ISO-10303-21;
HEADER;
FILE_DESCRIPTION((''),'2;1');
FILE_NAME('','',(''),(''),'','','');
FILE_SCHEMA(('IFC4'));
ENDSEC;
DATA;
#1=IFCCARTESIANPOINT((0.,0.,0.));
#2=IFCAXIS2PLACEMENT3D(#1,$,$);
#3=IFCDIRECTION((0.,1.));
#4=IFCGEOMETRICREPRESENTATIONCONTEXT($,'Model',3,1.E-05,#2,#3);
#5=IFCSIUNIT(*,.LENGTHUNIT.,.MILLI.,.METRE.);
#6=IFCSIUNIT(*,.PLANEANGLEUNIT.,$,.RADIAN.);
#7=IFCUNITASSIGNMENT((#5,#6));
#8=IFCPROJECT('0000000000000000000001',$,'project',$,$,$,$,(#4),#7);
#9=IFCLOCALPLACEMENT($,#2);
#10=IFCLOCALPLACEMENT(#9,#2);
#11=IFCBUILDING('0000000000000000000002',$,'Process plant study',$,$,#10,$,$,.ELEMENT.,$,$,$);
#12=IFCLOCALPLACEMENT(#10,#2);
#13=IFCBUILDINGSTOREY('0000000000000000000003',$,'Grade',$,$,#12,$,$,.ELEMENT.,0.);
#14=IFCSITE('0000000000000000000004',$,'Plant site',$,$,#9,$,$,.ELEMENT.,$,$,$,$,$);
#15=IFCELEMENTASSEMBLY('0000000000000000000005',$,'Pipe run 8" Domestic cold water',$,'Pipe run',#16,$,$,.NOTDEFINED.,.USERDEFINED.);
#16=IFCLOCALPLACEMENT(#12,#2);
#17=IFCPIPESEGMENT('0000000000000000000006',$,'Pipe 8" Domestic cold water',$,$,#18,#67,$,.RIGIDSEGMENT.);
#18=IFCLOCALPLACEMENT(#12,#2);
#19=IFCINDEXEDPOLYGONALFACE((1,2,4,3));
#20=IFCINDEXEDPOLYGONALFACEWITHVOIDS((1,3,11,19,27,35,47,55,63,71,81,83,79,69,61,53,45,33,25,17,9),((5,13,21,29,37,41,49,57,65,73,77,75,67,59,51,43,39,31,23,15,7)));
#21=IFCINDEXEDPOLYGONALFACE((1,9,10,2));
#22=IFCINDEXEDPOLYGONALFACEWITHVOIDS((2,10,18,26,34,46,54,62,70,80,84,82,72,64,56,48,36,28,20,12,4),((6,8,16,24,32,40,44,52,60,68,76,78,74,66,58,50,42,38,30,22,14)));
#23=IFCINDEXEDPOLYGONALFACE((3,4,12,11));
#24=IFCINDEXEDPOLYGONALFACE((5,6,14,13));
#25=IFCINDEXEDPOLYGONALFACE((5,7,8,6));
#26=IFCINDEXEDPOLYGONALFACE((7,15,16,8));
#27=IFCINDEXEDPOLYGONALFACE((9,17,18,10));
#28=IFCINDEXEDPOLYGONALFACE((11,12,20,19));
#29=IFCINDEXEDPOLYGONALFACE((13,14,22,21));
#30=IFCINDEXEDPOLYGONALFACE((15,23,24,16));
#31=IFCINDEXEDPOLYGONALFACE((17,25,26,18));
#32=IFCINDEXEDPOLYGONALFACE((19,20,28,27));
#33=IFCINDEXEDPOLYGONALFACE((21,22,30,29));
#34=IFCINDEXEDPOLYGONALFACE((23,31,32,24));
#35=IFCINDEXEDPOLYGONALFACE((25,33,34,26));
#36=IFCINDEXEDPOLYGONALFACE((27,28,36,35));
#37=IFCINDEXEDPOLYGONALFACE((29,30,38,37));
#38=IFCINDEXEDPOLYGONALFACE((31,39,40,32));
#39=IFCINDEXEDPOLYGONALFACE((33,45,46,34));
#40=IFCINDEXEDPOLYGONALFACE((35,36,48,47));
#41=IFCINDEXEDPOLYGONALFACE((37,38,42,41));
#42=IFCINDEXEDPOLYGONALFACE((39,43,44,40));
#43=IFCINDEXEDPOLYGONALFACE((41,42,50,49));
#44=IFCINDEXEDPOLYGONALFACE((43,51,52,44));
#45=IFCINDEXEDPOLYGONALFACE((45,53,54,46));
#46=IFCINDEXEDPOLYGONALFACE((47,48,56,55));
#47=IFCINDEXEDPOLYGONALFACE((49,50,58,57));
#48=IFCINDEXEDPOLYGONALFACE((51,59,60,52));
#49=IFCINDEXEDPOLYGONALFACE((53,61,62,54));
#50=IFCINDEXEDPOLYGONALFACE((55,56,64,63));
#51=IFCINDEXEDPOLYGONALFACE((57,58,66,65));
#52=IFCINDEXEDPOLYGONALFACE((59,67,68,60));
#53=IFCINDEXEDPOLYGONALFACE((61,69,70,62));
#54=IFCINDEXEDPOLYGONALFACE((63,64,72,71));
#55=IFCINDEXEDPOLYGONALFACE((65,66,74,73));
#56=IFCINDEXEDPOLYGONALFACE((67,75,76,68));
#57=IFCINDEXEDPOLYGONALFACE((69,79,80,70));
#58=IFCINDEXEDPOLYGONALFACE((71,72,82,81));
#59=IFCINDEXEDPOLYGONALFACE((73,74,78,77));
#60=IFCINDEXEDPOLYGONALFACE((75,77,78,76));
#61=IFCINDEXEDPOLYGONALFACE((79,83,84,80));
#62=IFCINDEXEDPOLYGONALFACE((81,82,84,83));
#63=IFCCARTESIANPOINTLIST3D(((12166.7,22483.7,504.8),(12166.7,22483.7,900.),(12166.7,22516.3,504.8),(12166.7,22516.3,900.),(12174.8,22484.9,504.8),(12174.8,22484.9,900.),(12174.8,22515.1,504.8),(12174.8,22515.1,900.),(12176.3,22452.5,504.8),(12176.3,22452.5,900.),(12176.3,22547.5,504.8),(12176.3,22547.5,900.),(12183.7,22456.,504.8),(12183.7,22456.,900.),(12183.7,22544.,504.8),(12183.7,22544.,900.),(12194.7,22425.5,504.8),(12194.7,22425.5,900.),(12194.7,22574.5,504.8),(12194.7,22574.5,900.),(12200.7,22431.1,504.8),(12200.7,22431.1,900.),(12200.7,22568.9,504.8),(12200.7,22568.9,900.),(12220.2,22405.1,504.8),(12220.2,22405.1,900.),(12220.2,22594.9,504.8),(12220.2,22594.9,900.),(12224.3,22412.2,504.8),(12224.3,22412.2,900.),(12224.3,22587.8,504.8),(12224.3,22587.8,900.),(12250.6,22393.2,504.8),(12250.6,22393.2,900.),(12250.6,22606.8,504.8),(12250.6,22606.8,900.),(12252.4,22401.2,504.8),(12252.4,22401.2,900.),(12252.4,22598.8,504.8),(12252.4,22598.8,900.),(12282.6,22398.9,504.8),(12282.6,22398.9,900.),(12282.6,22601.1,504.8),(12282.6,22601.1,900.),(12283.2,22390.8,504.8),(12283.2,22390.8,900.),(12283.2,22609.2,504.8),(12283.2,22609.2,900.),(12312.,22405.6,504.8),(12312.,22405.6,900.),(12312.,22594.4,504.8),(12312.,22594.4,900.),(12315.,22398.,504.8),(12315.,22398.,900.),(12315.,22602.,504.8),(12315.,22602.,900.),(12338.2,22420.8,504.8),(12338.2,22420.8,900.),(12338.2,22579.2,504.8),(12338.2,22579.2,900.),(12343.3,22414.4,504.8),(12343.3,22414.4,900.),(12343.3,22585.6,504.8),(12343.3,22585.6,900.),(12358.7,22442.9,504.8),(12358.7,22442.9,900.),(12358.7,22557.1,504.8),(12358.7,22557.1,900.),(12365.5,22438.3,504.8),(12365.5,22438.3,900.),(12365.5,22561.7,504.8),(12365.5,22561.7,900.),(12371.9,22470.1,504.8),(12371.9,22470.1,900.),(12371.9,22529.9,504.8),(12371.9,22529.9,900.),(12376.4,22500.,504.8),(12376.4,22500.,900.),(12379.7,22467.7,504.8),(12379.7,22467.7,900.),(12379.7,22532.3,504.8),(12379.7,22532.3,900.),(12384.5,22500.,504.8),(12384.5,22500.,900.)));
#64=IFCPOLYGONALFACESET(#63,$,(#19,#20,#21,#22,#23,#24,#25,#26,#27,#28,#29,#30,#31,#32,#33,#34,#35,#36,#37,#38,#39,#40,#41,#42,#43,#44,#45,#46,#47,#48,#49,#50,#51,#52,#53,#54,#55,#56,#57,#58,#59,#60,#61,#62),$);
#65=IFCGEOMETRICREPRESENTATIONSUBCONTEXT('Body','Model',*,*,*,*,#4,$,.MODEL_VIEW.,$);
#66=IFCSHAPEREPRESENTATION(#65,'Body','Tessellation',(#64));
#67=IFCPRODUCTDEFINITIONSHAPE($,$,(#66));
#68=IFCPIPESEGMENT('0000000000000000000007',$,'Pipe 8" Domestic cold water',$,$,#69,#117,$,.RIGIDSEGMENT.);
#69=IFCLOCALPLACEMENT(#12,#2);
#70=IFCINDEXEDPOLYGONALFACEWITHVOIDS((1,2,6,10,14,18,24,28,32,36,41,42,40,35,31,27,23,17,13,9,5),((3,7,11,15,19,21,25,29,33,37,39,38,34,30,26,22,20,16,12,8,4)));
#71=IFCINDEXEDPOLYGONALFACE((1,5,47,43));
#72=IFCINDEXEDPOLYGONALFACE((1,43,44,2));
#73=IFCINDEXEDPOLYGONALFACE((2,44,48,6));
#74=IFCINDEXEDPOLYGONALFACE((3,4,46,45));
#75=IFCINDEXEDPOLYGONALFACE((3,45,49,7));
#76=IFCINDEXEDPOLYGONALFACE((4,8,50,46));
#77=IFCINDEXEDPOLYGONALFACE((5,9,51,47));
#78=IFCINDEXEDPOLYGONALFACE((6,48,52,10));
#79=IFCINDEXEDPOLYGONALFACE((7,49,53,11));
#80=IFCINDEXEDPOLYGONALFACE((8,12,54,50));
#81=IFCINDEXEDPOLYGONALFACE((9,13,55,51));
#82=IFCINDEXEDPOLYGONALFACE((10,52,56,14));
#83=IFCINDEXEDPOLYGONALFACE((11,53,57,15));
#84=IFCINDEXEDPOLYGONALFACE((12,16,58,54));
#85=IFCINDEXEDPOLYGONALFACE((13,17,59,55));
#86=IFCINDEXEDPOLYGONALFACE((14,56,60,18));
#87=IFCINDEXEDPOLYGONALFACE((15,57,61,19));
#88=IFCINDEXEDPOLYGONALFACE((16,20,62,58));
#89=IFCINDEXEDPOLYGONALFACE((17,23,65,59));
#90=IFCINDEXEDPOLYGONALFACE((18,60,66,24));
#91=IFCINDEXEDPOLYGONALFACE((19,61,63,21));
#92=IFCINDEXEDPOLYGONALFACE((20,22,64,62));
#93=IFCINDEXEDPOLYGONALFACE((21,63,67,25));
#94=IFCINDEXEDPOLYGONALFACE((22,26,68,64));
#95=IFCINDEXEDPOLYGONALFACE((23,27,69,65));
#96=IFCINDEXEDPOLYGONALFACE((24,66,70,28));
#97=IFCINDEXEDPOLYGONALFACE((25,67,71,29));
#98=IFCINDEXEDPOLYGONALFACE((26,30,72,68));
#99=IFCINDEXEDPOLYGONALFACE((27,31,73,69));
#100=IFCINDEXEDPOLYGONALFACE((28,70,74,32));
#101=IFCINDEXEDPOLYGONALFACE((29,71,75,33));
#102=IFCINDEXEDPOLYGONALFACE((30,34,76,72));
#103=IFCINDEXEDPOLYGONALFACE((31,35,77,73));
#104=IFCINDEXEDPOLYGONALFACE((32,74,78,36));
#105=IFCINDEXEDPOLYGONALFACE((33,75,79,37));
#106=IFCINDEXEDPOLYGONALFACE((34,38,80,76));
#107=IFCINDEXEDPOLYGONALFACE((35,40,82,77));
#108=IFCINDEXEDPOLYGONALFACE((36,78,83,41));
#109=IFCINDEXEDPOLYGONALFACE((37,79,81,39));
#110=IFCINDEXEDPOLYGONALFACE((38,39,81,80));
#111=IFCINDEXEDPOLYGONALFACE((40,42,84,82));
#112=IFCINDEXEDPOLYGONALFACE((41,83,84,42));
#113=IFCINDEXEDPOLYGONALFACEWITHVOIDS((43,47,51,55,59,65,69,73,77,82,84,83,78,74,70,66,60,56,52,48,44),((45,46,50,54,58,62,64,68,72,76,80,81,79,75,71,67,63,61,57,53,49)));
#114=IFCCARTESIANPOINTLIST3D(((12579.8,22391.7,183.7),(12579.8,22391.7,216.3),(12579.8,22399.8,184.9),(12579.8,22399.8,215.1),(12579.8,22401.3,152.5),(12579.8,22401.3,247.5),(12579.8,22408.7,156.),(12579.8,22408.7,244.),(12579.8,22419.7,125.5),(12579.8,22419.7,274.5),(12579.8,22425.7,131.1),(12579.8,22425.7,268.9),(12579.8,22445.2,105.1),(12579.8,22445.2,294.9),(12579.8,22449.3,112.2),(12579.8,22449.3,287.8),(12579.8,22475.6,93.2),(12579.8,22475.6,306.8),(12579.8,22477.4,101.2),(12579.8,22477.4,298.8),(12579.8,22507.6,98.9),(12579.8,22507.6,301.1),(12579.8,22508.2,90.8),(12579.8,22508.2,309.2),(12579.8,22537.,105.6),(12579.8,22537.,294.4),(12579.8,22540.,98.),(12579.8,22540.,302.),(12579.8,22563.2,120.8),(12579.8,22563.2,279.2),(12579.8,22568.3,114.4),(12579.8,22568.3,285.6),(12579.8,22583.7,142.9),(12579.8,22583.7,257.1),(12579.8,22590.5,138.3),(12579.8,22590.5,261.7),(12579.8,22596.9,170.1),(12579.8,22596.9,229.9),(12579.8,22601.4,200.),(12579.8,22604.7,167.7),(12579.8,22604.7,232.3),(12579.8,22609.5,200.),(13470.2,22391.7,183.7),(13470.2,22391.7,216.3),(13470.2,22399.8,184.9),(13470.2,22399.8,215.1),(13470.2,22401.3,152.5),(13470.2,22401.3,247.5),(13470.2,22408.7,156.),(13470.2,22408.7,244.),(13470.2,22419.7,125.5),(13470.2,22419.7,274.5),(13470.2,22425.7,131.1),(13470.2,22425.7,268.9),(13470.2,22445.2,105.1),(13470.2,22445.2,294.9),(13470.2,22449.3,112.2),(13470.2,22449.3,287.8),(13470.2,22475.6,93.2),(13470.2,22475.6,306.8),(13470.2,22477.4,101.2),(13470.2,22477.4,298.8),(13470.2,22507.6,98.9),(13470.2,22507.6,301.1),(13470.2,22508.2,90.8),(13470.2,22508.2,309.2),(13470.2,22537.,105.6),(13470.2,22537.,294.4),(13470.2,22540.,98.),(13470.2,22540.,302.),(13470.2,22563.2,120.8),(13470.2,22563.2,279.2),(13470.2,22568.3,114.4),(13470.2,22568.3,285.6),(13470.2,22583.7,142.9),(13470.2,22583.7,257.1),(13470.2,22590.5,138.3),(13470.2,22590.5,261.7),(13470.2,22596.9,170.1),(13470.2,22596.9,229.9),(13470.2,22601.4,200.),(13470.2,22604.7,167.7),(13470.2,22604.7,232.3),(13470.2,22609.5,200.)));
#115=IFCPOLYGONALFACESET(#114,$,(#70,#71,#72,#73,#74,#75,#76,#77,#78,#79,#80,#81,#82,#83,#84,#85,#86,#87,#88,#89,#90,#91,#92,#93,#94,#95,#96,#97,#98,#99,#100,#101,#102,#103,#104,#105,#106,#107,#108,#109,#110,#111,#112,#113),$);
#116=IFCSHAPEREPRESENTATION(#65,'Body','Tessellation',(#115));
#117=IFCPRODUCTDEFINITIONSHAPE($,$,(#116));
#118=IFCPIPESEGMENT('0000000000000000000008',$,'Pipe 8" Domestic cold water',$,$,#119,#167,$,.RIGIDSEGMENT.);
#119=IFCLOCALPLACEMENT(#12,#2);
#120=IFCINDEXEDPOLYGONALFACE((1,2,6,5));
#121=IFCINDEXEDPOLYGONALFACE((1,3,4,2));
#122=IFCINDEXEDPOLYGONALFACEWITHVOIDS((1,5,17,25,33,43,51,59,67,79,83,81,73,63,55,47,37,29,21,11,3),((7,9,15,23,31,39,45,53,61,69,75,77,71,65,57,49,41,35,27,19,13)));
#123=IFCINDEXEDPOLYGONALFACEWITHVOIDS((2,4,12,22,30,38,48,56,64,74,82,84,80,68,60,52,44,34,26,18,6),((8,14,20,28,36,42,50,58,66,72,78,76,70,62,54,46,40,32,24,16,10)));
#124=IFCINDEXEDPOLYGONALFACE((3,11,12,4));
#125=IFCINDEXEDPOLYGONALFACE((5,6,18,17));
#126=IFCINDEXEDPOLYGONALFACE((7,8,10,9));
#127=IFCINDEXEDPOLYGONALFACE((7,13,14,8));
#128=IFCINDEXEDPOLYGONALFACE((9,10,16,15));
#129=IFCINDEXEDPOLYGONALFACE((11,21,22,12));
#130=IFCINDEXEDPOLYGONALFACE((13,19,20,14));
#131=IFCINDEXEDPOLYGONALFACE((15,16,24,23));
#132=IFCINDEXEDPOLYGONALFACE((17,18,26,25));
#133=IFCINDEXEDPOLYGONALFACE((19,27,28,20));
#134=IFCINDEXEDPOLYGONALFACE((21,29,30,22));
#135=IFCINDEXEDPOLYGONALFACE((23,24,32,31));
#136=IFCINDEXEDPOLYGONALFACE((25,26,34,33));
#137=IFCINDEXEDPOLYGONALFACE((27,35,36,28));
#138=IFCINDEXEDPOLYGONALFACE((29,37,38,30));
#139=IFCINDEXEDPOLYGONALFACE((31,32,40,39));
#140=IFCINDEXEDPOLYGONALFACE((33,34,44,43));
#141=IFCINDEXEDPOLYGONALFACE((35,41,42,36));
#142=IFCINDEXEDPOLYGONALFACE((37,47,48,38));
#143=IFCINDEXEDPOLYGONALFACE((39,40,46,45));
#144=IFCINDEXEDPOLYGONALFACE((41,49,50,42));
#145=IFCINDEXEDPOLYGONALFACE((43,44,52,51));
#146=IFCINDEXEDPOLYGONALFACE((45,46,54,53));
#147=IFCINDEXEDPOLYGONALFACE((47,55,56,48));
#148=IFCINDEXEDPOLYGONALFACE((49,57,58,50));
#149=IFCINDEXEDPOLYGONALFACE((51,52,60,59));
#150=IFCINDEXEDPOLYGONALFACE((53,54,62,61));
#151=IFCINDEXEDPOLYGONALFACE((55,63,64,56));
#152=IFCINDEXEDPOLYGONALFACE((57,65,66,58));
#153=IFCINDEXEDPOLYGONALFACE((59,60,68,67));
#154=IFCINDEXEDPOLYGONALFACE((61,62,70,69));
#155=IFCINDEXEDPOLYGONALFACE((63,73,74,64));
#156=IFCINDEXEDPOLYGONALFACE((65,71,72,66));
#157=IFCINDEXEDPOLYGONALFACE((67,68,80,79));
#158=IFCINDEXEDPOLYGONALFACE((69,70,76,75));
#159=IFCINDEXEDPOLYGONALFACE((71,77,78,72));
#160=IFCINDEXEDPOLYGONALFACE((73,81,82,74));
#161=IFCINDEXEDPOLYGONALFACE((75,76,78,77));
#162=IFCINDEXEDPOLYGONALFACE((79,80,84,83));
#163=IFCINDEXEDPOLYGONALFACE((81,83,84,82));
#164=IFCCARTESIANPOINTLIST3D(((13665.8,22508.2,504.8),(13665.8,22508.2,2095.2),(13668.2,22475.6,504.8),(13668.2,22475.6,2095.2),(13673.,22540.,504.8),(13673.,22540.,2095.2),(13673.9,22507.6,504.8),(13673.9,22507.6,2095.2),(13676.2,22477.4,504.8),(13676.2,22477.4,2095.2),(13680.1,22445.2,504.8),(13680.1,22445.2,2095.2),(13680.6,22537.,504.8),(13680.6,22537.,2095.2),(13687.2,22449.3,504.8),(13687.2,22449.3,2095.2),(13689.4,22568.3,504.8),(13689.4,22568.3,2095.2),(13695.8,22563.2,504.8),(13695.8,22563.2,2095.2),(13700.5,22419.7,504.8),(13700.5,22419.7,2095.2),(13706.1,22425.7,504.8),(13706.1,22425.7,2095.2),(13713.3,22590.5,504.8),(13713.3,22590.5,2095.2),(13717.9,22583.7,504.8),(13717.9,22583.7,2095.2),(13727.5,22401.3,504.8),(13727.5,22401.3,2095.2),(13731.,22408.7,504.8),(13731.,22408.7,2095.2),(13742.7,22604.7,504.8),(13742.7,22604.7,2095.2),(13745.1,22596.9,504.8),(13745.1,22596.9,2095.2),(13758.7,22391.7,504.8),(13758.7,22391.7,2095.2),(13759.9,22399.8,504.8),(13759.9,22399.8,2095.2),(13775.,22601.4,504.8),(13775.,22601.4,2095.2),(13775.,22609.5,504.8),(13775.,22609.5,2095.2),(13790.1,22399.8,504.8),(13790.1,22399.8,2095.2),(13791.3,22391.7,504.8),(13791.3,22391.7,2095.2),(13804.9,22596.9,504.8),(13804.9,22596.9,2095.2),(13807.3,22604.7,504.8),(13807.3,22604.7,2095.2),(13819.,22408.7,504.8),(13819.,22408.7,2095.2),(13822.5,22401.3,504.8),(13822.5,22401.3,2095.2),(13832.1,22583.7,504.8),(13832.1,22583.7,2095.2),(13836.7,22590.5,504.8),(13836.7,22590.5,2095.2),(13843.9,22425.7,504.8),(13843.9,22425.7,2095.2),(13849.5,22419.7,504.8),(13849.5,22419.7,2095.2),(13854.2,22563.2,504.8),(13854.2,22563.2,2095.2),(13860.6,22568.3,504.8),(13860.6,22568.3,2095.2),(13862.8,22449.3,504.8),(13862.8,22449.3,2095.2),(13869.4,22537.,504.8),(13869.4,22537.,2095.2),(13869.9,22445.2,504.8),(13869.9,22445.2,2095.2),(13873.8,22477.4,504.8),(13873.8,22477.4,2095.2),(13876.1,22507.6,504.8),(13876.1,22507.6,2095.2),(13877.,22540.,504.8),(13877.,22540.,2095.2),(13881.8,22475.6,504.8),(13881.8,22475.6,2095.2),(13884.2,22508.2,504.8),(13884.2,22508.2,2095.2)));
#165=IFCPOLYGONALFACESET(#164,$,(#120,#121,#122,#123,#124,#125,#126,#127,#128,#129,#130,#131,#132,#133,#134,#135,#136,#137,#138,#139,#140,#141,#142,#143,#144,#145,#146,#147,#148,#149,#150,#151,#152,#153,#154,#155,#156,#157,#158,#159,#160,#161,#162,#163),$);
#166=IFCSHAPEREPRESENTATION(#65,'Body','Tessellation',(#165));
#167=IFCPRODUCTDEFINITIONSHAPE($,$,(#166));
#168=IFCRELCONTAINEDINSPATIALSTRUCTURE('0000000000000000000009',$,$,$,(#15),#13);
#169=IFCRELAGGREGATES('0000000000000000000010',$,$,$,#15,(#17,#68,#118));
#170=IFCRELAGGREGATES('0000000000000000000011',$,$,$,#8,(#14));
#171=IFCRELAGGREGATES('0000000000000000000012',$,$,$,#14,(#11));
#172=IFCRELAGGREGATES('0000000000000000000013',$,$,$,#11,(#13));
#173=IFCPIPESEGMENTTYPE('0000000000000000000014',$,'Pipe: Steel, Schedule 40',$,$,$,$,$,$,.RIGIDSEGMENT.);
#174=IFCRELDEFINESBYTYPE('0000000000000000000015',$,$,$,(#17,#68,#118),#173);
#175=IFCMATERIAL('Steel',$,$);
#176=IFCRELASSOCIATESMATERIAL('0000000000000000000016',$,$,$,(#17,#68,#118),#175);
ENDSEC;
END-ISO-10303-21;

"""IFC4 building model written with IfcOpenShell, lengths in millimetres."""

from ifc_helpers import new_model, si_unit, direction, frame, origin, origin_with_axes, origin_2d, place, context, subcontext, project, spatial, hollow_circle, extrude, material, type_object, element, aggregate, save


model = new_model("IFC4")

# Units and contexts
model_context = context("Model", 3, precision=1e-05, world=origin(), true_north=direction((0.0, 1.0)))
body_context = subcontext(model_context, "Body", "Model", "MODEL_VIEW")
ifc_project = project(units=[si_unit("LENGTHUNIT", "METRE", prefix="MILLI"), si_unit("PLANEANGLEUNIT", "RADIAN")], contexts=[model_context])

# Site, building, storey
site_placement = place(None, origin())
site = spatial("IfcSite", under=ifc_project, at=site_placement, Name="Plant site", CompositionType="ELEMENT")
building_placement = place(site_placement, origin())
building = spatial("IfcBuilding", under=site, at=building_placement, Name="Process plant study", CompositionType="ELEMENT")
storey_placement = place(building_placement, origin())
storey = spatial("IfcBuildingStorey", under=building, at=storey_placement, Name="Grade", CompositionType="ELEMENT", Elevation=0.0)

# Shared definitions
ifc_material = material(Name="Steel")
pipe_segment_type = type_object("IfcPipeSegmentType", Name="Pipe: Steel, Schedule 40", PredefinedType="RIGIDSEGMENT")

# Element assembly, pipe segments
assembly_1_placement = place(storey_placement, origin_with_axes())
assembly_1 = element("IfcElementAssembly", 1, at=assembly_1_placement, inside=storey, Name="Pipe run 8\" Domestic cold water", ObjectType="Pipe run", AssemblyPlace="NOTDEFINED", PredefinedType="USERDEFINED")
pipe_segment_1_placement = place(storey_placement, origin_with_axes())
pipe_segment_1 = element("IfcPipeSegment", 2, at=pipe_segment_1_placement, type_object=pipe_segment_type, material=ifc_material, Name="Pipe 8\" Domestic cold water", PredefinedType="RIGIDSEGMENT", context=body_context, shape_type="SweptSolid", body=[
    extrude(hollow_circle(Radius=109.5, WallThickness=8.2, at=origin_2d()), frame((12275.0, 22500.0, 900.0), z_axis=(0.0, 0.0, -1.0), x_axis=(1.0, 0.0, 0.0)), (0.0, 0.0, 1.0), 395.2),
])
pipe_segment_2_placement = place(storey_placement, origin_with_axes())
pipe_segment_2 = element("IfcPipeSegment", 3, at=pipe_segment_2_placement, type_object=pipe_segment_type, material=ifc_material, Name="Pipe 8\" Domestic cold water", PredefinedType="RIGIDSEGMENT", context=body_context, shape_type="SweptSolid", body=[
    extrude(hollow_circle(Radius=109.5, WallThickness=8.2, at=origin_2d()), frame((12579.8, 22500.0, 200.0), z_axis=(1.0, 0.0, 0.0), x_axis=(0.0, 1.0, 0.0)), (0.0, 0.0, 1.0), 890.4),
])
pipe_segment_3_placement = place(storey_placement, origin_with_axes())
pipe_segment_3 = element("IfcPipeSegment", 4, at=pipe_segment_3_placement, type_object=pipe_segment_type, material=ifc_material, Name="Pipe 8\" Domestic cold water", PredefinedType="RIGIDSEGMENT", context=body_context, shape_type="SweptSolid", body=[
    extrude(hollow_circle(Radius=109.5, WallThickness=8.2, at=origin_2d()), frame((13775.0, 22500.0, 504.8), z_axis=(0.0, 0.0, 1.0), x_axis=(0.0, 1.0, 0.0)), (0.0, 0.0, 1.0), 1590.4),
])

aggregate(assembly_1, [pipe_segment_1, pipe_segment_2, pipe_segment_3])

save(model, "model.ifc")
